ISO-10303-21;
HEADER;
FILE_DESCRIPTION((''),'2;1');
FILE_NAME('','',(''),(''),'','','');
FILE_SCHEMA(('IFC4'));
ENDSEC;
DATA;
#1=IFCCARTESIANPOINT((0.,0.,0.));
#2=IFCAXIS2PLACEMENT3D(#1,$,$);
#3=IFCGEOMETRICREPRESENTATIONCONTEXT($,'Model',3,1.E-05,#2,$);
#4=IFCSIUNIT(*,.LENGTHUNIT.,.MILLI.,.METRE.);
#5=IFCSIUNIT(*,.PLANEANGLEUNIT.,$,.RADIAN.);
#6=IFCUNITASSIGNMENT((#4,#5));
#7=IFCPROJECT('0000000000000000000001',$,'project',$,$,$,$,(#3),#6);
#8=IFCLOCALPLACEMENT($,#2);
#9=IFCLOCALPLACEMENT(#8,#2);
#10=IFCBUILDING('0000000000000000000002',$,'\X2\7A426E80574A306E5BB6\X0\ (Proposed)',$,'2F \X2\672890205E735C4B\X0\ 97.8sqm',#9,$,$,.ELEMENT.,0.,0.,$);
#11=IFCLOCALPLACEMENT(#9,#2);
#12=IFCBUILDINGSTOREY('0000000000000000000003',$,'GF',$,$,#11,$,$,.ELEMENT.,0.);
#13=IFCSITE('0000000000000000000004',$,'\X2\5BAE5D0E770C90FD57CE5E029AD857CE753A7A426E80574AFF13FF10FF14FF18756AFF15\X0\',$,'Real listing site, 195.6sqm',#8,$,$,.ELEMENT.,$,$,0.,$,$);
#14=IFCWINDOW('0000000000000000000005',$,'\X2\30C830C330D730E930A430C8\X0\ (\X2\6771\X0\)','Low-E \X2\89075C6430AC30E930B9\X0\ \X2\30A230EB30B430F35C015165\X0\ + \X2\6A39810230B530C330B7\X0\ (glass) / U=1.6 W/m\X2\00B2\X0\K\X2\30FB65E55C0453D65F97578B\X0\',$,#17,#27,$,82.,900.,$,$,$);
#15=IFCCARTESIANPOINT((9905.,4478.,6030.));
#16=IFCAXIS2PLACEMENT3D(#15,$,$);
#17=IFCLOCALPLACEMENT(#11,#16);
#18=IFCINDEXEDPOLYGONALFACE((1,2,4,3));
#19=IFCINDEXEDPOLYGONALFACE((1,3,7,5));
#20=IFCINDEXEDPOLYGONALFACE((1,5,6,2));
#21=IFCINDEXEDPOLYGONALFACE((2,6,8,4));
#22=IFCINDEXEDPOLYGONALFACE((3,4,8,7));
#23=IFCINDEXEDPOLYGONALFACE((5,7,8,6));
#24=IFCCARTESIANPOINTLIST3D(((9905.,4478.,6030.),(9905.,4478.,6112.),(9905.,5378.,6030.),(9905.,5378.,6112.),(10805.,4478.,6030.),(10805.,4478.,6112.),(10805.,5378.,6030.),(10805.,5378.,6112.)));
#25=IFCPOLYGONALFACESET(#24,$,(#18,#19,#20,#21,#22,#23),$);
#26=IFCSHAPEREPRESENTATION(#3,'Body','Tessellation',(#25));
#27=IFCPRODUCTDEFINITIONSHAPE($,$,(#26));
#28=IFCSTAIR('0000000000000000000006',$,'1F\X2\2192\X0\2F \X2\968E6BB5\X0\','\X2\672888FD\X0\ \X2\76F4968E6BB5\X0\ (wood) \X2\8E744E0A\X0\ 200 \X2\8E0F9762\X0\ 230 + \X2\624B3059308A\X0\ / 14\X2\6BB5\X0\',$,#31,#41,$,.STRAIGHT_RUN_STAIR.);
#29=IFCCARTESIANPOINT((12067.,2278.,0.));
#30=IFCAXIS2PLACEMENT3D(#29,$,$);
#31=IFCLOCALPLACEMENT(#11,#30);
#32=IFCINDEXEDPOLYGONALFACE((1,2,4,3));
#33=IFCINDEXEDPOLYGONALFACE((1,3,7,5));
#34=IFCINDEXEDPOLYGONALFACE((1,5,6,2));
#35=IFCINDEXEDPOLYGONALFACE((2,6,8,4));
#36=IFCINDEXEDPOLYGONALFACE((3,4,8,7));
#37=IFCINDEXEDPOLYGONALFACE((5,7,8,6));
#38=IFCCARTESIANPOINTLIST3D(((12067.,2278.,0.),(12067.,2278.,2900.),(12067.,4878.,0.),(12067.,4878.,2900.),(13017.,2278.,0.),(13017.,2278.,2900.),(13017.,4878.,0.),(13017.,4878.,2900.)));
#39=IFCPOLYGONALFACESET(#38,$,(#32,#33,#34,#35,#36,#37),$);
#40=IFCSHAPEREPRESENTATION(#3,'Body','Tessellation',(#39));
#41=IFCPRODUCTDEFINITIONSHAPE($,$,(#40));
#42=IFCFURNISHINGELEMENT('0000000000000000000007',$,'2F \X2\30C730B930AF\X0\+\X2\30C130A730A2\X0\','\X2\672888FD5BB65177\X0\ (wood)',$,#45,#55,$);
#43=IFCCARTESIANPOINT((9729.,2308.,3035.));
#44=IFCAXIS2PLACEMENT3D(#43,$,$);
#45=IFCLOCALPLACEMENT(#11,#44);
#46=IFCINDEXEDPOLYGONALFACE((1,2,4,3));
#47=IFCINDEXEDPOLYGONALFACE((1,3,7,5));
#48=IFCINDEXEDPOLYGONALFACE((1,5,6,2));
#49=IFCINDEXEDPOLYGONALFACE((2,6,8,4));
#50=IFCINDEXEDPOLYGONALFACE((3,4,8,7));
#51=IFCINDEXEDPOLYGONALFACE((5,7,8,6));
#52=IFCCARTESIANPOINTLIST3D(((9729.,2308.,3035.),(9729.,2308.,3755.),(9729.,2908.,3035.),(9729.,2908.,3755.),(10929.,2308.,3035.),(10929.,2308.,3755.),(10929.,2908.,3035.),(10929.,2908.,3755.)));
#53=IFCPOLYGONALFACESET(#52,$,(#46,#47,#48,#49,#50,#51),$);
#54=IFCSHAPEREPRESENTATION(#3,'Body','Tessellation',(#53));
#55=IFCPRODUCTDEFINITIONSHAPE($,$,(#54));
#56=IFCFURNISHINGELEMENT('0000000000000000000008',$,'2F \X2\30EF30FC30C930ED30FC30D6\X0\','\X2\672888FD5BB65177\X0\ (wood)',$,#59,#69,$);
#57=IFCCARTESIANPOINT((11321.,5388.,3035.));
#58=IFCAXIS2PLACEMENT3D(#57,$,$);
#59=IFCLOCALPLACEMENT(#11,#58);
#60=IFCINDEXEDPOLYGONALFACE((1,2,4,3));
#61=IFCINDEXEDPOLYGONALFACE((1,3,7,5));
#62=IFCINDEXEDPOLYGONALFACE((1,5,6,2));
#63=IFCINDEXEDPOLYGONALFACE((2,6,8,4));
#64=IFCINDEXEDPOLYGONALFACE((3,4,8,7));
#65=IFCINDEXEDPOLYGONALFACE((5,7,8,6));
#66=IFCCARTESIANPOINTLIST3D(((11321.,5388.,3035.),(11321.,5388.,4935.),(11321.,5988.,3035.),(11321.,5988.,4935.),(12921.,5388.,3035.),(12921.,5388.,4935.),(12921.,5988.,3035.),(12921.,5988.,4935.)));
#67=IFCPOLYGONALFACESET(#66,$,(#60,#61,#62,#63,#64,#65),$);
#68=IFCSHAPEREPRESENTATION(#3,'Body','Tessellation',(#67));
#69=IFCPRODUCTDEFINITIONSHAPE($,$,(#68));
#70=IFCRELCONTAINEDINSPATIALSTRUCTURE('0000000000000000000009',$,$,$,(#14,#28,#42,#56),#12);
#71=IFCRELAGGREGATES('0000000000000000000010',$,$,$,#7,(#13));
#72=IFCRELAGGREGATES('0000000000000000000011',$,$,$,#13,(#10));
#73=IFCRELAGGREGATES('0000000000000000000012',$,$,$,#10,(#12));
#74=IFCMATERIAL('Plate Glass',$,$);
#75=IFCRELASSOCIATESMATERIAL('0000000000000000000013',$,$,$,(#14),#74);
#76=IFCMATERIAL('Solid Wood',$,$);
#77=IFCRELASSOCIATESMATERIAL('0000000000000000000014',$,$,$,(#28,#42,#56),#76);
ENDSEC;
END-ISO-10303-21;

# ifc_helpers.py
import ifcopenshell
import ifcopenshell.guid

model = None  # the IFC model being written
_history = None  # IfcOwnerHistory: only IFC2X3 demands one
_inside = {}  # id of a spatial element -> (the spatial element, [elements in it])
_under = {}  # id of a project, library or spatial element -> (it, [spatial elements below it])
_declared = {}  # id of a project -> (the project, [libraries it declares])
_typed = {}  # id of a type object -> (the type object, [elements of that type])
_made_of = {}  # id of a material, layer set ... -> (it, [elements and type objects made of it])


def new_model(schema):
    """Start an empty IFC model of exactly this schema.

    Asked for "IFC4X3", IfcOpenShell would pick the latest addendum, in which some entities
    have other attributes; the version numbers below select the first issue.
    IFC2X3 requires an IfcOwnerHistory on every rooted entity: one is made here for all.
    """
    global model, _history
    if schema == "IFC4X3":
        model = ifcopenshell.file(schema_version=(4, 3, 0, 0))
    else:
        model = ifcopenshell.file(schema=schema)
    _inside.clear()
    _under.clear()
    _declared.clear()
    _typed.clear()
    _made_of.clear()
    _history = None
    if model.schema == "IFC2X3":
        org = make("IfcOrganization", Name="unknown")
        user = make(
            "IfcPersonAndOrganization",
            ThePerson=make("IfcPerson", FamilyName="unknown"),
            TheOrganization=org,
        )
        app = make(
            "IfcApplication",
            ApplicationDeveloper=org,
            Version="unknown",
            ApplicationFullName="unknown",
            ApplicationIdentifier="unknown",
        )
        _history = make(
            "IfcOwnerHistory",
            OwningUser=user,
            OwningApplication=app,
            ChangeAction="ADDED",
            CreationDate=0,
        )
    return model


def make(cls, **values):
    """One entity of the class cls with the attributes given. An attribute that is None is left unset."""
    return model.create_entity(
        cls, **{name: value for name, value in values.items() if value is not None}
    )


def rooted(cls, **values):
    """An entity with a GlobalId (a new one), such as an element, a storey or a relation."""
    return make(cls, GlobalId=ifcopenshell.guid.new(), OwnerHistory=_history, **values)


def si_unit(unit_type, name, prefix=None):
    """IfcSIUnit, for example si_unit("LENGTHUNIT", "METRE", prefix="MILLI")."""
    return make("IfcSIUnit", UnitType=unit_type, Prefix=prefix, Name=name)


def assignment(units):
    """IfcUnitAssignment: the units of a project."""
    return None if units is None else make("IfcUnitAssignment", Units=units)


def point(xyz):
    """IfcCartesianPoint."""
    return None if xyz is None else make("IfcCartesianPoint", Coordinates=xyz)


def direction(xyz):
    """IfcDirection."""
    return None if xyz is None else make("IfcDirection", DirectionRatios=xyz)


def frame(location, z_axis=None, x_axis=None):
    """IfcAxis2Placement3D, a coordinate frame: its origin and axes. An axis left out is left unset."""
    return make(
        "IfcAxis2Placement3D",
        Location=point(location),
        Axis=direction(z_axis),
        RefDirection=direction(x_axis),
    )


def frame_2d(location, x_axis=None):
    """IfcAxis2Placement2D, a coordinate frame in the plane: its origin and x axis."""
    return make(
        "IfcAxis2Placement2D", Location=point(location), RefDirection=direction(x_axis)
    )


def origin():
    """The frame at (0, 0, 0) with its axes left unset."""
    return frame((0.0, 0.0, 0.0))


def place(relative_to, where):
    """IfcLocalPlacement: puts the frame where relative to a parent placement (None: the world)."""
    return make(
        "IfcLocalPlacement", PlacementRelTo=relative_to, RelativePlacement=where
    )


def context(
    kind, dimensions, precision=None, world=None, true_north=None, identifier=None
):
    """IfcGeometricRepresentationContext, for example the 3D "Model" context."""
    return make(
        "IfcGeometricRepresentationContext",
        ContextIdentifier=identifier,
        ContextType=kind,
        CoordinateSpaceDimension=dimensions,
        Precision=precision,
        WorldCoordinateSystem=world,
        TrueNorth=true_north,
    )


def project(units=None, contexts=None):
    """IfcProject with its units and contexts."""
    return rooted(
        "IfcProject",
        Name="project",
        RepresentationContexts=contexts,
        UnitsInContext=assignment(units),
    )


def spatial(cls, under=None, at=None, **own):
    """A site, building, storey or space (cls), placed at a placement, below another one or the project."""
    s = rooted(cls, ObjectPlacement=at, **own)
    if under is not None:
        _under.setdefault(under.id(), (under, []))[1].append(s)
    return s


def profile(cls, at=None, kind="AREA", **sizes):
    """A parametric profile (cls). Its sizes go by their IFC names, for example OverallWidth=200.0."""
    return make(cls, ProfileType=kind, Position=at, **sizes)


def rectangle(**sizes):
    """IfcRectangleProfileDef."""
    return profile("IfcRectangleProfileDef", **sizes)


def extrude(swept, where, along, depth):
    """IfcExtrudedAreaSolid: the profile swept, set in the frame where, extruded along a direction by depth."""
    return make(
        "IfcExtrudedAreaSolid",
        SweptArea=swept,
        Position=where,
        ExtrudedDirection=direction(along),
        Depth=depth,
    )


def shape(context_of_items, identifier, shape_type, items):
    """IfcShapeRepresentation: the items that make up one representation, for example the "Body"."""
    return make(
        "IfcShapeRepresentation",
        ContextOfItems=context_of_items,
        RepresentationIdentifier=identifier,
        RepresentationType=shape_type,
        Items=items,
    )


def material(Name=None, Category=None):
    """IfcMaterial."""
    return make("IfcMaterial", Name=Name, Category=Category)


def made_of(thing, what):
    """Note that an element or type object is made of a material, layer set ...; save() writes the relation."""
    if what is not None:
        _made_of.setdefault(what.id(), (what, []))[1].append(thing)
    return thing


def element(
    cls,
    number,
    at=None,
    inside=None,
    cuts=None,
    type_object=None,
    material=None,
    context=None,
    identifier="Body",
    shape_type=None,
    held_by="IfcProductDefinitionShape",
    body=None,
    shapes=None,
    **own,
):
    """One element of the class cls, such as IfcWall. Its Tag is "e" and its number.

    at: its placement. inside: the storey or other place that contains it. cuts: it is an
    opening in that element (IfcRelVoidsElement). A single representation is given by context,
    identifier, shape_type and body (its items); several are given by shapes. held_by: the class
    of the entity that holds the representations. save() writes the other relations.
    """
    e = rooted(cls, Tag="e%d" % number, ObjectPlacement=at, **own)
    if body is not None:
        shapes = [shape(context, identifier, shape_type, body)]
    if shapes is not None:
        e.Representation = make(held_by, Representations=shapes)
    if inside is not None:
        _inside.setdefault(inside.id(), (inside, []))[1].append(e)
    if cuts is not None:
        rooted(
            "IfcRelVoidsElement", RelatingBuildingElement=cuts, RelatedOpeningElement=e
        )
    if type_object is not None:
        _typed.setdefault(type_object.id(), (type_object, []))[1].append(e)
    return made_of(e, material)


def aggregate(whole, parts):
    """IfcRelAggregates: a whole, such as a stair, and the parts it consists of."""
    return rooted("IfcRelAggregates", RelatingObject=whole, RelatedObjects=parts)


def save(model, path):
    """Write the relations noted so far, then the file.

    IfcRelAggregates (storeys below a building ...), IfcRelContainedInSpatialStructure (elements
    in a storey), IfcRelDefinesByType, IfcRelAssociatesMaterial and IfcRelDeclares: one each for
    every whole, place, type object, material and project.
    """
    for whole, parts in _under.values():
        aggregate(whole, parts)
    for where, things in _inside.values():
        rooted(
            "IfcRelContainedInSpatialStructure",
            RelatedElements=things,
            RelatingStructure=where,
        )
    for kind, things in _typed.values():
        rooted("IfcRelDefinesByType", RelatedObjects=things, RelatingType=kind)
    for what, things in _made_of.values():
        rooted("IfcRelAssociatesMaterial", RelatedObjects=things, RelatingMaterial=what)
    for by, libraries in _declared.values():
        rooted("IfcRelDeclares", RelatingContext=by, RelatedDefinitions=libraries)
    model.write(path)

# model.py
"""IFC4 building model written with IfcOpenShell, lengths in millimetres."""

from ifc_helpers import new_model, si_unit, frame, frame_2d, origin, place, context, project, spatial, rectangle, extrude, material, element, save


model = new_model("IFC4")

# Units and contexts
model_context = context("Model", 3, precision=1e-05, world=origin())
ifc_project = project(units=[si_unit("LENGTHUNIT", "METRE", prefix="MILLI"), si_unit("PLANEANGLEUNIT", "RADIAN")], contexts=[model_context])

# Site, building, storey
site_placement = place(None, origin())
site = spatial("IfcSite", under=ifc_project, at=site_placement, Name="宮崎県都城市高城町穂満坊３０４８番５", ObjectType="Real listing site, 195.6sqm", CompositionType="ELEMENT", RefElevation=0.0)
building_placement = place(site_placement, origin())
building = spatial("IfcBuilding", under=site, at=building_placement, Name="穂満坊の家 (Proposed)", ObjectType="2F 木造平屋 97.8sqm", CompositionType="ELEMENT", ElevationOfRefHeight=0.0, ElevationOfTerrain=0.0)
storey_placement = place(building_placement, origin())
storey = spatial("IfcBuildingStorey", under=building, at=storey_placement, Name="GF", CompositionType="ELEMENT", Elevation=0.0)

# Shared definitions
ifc_material_1 = material(Name="Solid Wood")

# Shared definitions
ifc_material_2 = material(Name="Plate Glass")

# Window
window_1_placement = place(storey_placement, frame((9905.0, 4478.0, 6030.0)))
element("IfcWindow", 1, at=window_1_placement, inside=storey, material=ifc_material_2, Name="トップライト (東)", Description="Low-E 複層ガラス アルゴン封入 + 樹脂サッシ (glass) / U=1.6 W/m²K・日射取得型", OverallHeight=82.0, OverallWidth=900.0, context=model_context, shape_type="SweptSolid", body=[
    extrude(rectangle(XDim=900.0, YDim=900.0, at=frame_2d((450.0, 450.0))), frame((9905.0, 4478.0, 6030.0)), (0.0, 0.0, 1.0), 82.0),
])

# Stair
stair_placement = place(storey_placement, frame((12067.0, 2278.0, 0.0)))
element("IfcStair", 2, at=stair_placement, inside=storey, material=ifc_material_1, Name="1F→2F 階段", Description="木製 直階段 (wood) 蹴上 200 踏面 230 + 手すり / 14段", PredefinedType="STRAIGHT_RUN_STAIR", context=model_context, shape_type="SweptSolid", body=[
    extrude(rectangle(XDim=950.0, YDim=2600.0, at=frame_2d((475.0, 1300.0))), frame((12067.0, 2278.0, 0.0)), (0.0, 0.0, 1.0), 2900.0),
])

# Furnishing elements
furnishing_1_placement = place(storey_placement, frame((9729.0, 2308.0, 3035.0)))
element("IfcFurnishingElement", 3, at=furnishing_1_placement, inside=storey, material=ifc_material_1, Name="2F デスク+チェア", Description="木製家具 (wood)", context=model_context, shape_type="SweptSolid", body=[
    extrude(rectangle(XDim=1200.0, YDim=600.0, at=frame_2d((600.0, 300.0))), frame((9729.0, 2308.0, 3035.0)), (0.0, 0.0, 1.0), 720.0),
])
furnishing_2_placement = place(storey_placement, frame((11321.0, 5388.0, 3035.0)))
element("IfcFurnishingElement", 4, at=furnishing_2_placement, inside=storey, material=ifc_material_1, Name="2F ワードローブ", Description="木製家具 (wood)", context=model_context, shape_type="SweptSolid", body=[
    extrude(rectangle(XDim=1600.0, YDim=600.0, at=frame_2d((800.0, 300.0))), frame((11321.0, 5388.0, 3035.0)), (0.0, 0.0, 1.0), 1900.0),
])

save(model, "model.ifc")
